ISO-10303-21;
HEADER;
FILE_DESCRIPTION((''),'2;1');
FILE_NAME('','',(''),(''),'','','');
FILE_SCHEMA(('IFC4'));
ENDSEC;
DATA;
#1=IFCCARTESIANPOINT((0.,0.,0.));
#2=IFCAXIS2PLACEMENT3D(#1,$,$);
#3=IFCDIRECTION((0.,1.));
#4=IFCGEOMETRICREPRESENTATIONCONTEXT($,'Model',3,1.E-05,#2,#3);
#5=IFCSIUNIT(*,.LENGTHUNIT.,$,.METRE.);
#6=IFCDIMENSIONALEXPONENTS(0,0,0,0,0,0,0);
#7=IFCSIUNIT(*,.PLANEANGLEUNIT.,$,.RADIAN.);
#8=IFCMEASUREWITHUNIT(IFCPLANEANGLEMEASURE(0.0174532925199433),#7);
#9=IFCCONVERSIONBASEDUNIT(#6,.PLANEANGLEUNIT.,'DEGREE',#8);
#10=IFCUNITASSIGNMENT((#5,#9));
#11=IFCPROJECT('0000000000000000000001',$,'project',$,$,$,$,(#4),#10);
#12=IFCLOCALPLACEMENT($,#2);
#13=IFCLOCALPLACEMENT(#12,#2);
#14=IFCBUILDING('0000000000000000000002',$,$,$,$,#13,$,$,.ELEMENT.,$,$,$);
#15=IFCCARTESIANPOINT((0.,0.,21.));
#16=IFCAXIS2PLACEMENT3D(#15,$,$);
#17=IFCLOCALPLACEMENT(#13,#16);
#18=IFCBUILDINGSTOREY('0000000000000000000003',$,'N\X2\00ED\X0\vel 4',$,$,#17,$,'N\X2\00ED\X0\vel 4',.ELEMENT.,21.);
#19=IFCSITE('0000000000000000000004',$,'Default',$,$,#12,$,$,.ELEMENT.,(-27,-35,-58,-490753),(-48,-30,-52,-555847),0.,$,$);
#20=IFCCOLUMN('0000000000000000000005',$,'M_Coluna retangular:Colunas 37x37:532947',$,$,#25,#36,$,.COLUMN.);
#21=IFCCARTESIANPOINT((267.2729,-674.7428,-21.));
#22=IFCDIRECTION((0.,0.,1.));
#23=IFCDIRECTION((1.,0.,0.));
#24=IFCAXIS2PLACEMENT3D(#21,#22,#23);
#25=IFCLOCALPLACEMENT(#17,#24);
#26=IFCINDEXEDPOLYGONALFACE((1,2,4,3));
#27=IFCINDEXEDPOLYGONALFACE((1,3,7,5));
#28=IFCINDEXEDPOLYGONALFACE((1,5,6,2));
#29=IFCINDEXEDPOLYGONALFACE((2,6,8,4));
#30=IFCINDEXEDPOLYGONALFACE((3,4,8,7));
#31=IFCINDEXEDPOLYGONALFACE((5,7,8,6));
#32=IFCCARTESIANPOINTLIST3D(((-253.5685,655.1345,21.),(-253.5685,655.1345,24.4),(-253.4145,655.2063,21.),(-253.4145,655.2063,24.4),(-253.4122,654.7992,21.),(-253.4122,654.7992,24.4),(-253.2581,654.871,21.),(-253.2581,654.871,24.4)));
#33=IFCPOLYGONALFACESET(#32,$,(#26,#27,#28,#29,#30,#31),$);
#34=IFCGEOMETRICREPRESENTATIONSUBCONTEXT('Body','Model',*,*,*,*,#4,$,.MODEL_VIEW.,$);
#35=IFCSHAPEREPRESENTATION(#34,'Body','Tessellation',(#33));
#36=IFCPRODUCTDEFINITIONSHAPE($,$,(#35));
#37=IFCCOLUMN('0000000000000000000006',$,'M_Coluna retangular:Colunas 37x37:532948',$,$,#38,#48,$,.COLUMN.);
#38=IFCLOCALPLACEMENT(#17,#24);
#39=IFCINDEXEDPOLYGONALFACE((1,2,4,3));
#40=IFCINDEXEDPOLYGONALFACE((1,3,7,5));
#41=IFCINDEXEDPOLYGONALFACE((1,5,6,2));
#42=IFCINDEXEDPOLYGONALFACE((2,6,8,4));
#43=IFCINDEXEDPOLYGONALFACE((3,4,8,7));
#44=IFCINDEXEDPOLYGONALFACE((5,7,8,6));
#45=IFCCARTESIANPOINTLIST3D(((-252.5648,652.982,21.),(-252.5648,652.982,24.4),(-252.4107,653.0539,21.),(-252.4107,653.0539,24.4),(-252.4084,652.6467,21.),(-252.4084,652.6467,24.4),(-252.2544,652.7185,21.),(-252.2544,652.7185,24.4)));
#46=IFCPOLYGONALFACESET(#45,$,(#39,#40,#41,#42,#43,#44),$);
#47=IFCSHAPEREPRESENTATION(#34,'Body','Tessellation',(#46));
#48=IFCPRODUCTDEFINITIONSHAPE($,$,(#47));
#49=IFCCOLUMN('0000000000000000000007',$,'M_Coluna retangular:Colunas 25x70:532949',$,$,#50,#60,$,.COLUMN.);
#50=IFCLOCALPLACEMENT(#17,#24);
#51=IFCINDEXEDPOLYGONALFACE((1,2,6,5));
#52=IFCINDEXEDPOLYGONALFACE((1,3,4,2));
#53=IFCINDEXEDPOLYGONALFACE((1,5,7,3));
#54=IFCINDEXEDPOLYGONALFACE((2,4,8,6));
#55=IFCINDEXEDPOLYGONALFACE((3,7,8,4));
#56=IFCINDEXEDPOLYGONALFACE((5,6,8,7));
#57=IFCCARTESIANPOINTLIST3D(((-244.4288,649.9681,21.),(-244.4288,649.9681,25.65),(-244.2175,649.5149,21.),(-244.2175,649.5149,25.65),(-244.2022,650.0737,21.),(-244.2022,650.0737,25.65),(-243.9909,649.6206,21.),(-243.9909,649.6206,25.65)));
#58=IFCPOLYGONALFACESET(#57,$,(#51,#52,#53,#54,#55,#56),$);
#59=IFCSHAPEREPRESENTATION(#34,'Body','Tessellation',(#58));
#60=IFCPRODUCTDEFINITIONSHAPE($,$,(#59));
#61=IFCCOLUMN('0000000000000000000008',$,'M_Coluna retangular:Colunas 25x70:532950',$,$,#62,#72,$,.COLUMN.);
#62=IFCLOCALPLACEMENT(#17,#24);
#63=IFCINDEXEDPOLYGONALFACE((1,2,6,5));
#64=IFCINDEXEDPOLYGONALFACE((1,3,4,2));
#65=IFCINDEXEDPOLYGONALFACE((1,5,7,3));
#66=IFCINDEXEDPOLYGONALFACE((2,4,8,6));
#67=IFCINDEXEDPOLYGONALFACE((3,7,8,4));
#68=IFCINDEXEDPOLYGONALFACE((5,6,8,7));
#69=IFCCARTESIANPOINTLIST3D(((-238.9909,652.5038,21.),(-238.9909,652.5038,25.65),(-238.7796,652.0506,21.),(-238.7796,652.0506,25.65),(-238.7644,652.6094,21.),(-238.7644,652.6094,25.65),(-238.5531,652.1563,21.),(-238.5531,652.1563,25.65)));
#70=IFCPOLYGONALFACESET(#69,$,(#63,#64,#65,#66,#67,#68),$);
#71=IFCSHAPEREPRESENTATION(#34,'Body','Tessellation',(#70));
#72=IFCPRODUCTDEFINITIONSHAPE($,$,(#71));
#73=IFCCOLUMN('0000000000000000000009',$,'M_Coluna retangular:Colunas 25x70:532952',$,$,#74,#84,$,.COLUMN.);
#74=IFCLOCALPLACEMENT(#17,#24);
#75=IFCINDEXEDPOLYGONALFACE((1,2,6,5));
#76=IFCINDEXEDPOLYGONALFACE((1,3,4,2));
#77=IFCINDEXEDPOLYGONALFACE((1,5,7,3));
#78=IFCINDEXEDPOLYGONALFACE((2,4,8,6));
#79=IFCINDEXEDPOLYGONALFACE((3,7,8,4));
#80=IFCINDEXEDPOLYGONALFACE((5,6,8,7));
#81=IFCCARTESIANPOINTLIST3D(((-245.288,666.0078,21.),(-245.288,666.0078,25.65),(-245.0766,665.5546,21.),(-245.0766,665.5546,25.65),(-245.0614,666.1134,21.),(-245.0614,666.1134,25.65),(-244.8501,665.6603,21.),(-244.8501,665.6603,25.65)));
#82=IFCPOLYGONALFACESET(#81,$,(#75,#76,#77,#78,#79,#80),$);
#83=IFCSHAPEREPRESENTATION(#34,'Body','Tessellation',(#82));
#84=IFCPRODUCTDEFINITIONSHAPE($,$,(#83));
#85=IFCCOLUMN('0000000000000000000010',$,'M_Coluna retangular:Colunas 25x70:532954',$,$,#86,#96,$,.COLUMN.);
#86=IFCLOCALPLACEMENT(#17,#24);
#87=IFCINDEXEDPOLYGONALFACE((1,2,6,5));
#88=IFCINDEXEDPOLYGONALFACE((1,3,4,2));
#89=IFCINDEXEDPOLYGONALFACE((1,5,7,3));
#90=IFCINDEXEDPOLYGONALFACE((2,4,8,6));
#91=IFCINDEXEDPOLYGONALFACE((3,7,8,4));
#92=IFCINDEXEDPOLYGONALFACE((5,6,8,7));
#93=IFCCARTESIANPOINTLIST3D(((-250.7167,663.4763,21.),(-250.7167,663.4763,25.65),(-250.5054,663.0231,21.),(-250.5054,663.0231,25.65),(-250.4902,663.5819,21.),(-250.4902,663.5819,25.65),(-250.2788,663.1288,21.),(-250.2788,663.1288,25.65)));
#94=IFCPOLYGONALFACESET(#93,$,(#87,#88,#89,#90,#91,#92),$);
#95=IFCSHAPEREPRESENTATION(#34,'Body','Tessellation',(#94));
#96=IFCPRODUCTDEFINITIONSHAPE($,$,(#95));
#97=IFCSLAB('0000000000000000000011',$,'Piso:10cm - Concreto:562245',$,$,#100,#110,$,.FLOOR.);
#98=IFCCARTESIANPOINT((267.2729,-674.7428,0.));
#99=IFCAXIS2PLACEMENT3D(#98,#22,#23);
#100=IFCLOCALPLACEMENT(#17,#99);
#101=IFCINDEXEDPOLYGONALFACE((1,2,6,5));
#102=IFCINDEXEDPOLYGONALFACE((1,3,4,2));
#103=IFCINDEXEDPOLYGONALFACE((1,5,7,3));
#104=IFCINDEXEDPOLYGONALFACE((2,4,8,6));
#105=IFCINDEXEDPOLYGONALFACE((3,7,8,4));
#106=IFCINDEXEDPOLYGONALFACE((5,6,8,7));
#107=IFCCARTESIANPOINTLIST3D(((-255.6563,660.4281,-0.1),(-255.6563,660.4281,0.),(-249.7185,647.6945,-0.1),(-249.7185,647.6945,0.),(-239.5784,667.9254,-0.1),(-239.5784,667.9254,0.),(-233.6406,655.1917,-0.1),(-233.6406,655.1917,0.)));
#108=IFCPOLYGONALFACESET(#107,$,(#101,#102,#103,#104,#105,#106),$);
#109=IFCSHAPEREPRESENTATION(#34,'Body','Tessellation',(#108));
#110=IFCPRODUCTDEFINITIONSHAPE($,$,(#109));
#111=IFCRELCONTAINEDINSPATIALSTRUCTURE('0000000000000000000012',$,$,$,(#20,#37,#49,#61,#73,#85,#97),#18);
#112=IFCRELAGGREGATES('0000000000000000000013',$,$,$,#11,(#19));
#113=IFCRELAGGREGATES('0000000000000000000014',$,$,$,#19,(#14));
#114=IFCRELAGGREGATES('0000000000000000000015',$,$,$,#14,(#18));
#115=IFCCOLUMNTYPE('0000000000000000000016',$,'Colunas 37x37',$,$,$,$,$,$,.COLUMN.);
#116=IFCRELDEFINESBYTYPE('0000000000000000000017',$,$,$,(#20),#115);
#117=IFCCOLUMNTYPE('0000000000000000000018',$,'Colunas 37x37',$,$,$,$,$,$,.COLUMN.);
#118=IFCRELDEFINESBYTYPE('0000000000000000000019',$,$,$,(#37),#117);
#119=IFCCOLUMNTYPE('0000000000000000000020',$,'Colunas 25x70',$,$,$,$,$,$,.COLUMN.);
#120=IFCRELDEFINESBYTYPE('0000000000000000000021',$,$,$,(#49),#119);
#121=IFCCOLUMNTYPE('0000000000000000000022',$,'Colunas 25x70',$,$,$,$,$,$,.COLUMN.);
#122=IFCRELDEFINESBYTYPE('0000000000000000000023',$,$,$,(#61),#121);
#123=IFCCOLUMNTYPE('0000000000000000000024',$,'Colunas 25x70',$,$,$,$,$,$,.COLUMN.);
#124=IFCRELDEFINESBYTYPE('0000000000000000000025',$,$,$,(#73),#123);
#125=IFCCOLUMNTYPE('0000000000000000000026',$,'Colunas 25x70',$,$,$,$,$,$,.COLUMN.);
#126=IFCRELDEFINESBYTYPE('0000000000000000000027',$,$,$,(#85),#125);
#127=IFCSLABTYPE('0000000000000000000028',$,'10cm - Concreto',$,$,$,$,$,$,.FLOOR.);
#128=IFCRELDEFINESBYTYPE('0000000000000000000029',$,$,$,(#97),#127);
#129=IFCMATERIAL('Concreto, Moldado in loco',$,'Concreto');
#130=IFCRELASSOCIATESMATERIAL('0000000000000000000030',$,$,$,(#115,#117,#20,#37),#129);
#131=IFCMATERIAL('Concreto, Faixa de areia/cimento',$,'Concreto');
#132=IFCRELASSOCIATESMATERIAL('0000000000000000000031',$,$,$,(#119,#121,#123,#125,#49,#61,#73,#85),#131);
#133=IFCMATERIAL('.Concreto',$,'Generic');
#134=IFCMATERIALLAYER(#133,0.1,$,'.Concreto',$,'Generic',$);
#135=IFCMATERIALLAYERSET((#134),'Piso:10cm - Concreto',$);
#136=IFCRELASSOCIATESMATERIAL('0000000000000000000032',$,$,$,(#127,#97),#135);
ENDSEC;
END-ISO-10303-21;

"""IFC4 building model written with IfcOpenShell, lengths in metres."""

from ifc_helpers import new_model, entity, si_unit, converted_unit, direction, frame, frame_2d, origin, origin_2d_with_axis, place, context, subcontext, project, spatial, rectangle, extrude, source, transform, mapped, material, layer, layer_set, layer_usage, material_profile, profile_set, profile_usage, type_object, type_shapes, element, save


model = new_model("IFC4")

# Units and contexts
model_context = context("Model", 3, precision=1e-05, world=origin(), true_north=direction((0.0, 1.0)))
body_context = subcontext(model_context, "Body", "Model", "MODEL_VIEW")
ifc_project = project(units=[si_unit("LENGTHUNIT", "METRE"), converted_unit("PLANEANGLEUNIT", "DEGREE", entity("IfcPlaneAngleMeasure", 0.0174532925199433), si_unit("PLANEANGLEUNIT", "RADIAN"), dimensions=[0, 0, 0, 0, 0, 0, 0])], contexts=[model_context])

# Site, building, storey
site_placement = place(None, origin())
site = spatial("IfcSite", under=ifc_project, at=site_placement, Name="Default", CompositionType="ELEMENT", RefLatitude=(-27, -35, -58, -490753), RefLongitude=(-48, -30, -52, -555847), RefElevation=0.0)
building_placement = place(site_placement, origin())
building = spatial("IfcBuilding", under=site, at=building_placement, CompositionType="ELEMENT")
storey_placement = place(building_placement, frame((0.0, 0.0, 21.0)))
storey = spatial("IfcBuildingStorey", under=building, at=storey_placement, Name="Nível 4", LongName="Nível 4", CompositionType="ELEMENT", Elevation=21.0)

# Columns
ifc_material_1 = material(Name="Concreto, Faixa de areia/cimento", Category="Concreto")
ifc_material_profile_1 = material_profile(ifc_material_1, rectangle(XDim=0.5, YDim=0.25, at=frame_2d((-0.05, 0.015), x_axis=(1.0, 0.0))), Name="Colunas 25x70")
ifc_profile_set_1 = profile_set([ifc_material_profile_1], Name="Colunas 25x70")
ifc_profile_usage_1 = profile_usage(ifc_profile_set_1)
ifc_material_2 = material(Name="Concreto, Moldado in loco", Category="Concreto")
ifc_material_profile_2 = material_profile(ifc_material_2, rectangle(XDim=0.37, YDim=0.37, at=origin_2d_with_axis()), Name="Colunas 37x37")
ifc_profile_set_2 = profile_set([ifc_material_profile_2], Name="Colunas 37x37")
ifc_profile_usage_2 = profile_usage(ifc_profile_set_2)
column_type_1 = type_object("IfcColumnType", Name="Colunas 37x37", PredefinedType="COLUMN", material=ifc_profile_set_2)
shared_shape_1 = source(origin(), body_context, "Body", "SweptSolid", [
    extrude(rectangle(XDim=0.17, YDim=0.37, at=frame_2d((0.0, 0.0), x_axis=(1.0, 0.0))), frame((-253.4133, 655.0027, 21.0), z_axis=(0.0, 0.0, 1.0), x_axis=(0.906308, 0.422618, 0.0)), (0.0, 0.0, 1.0), 3.4),
])
type_shapes(column_type_1, [shared_shape_1])
column_1_placement = place(storey_placement, frame((267.2729, -674.7428, -21.0), z_axis=(0.0, 0.0, 1.0), x_axis=(1.0, 0.0, 0.0)))
element("IfcColumn", 1, at=column_1_placement, inside=storey, type_object=column_type_1, material=ifc_profile_usage_2, Name="M_Coluna retangular:Colunas 37x37:532947", PredefinedType="COLUMN", context=body_context, shape_type="MappedRepresentation", body=[
    mapped(shared_shape_1, transform((0.0, 0.0, 0.0), scale=1.0)),
])
column_type_2 = type_object("IfcColumnType", Name="Colunas 37x37", PredefinedType="COLUMN", material=ifc_profile_set_2)
shared_shape_2 = source(origin(), body_context, "Body", "SweptSolid", [
    extrude(rectangle(XDim=0.17, YDim=0.37, at=frame_2d((0.0, 0.0), x_axis=(1.0, 0.0))), frame((-252.4096, 652.8503, 21.0), z_axis=(0.0, 0.0, 1.0), x_axis=(0.906308, 0.422618, 0.0)), (0.0, 0.0, 1.0), 3.4),
])
type_shapes(column_type_2, [shared_shape_2])
column_2_placement = place(storey_placement, frame((267.2729, -674.7428, -21.0), z_axis=(0.0, 0.0, 1.0), x_axis=(1.0, 0.0, 0.0)))
element("IfcColumn", 2, at=column_2_placement, inside=storey, type_object=column_type_2, material=ifc_profile_usage_2, Name="M_Coluna retangular:Colunas 37x37:532948", PredefinedType="COLUMN", context=body_context, shape_type="MappedRepresentation", body=[
    mapped(shared_shape_2, transform((0.0, 0.0, 0.0), scale=1.0)),
])
column_type_3 = type_object("IfcColumnType", Name="Colunas 25x70", PredefinedType="COLUMN", material=ifc_profile_set_1)
shared_shape_3 = source(origin(), body_context, "Body", "SweptSolid", [
    extrude(rectangle(XDim=0.5, YDim=0.25, at=frame_2d((0.0, 0.0), x_axis=(1.0, 0.0))), frame((-244.2098, 649.7943, 21.0), z_axis=(0.0, 0.0, 1.0), x_axis=(-0.422618, 0.906308, 0.0)), (0.0, 0.0, 1.0), 4.65),
])
type_shapes(column_type_3, [shared_shape_3])
column_3_placement = place(storey_placement, frame((267.2729, -674.7428, -21.0), z_axis=(0.0, 0.0, 1.0), x_axis=(1.0, 0.0, 0.0)))
element("IfcColumn", 3, at=column_3_placement, inside=storey, type_object=column_type_3, material=ifc_profile_usage_1, Name="M_Coluna retangular:Colunas 25x70:532949", PredefinedType="COLUMN", context=body_context, shape_type="MappedRepresentation", body=[
    mapped(shared_shape_3, transform((0.0, 0.0, 0.0), scale=1.0)),
])
column_type_4 = type_object("IfcColumnType", Name="Colunas 25x70", PredefinedType="COLUMN", material=ifc_profile_set_1)
shared_shape_4 = source(origin(), body_context, "Body", "SweptSolid", [
    extrude(rectangle(XDim=0.5, YDim=0.25, at=frame_2d((0.0, 0.0), x_axis=(1.0, 0.0))), frame((-238.772, 652.33, 21.0), z_axis=(0.0, 0.0, 1.0), x_axis=(-0.422618, 0.906308, 0.0)), (0.0, 0.0, 1.0), 4.65),
])
type_shapes(column_type_4, [shared_shape_4])
column_4_placement = place(storey_placement, frame((267.2729, -674.7428, -21.0), z_axis=(0.0, 0.0, 1.0), x_axis=(1.0, 0.0, 0.0)))
element("IfcColumn", 4, at=column_4_placement, inside=storey, type_object=column_type_4, material=ifc_profile_usage_1, Name="M_Coluna retangular:Colunas 25x70:532950", PredefinedType="COLUMN", context=body_context, shape_type="MappedRepresentation", body=[
    mapped(shared_shape_4, transform((0.0, 0.0, 0.0), scale=1.0)),
])
column_type_5 = type_object("IfcColumnType", Name="Colunas 25x70", PredefinedType="COLUMN", material=ifc_profile_set_1)
shared_shape_5 = source(origin(), body_context, "Body", "SweptSolid", [
    extrude(rectangle(XDim=0.5, YDim=0.25, at=frame_2d((0.0, 0.0), x_axis=(1.0, 0.0))), frame((-245.069, 665.834, 21.0), z_axis=(0.0, 0.0, 1.0), x_axis=(0.422618, -0.906308, 0.0)), (0.0, 0.0, 1.0), 4.65),
])
type_shapes(column_type_5, [shared_shape_5])
column_5_placement = place(storey_placement, frame((267.2729, -674.7428, -21.0), z_axis=(0.0, 0.0, 1.0), x_axis=(1.0, 0.0, 0.0)))
element("IfcColumn", 5, at=column_5_placement, inside=storey, type_object=column_type_5, material=ifc_profile_usage_1, Name="M_Coluna retangular:Colunas 25x70:532952", PredefinedType="COLUMN", context=body_context, shape_type="MappedRepresentation", body=[
    mapped(shared_shape_5, transform((0.0, 0.0, 0.0), scale=1.0)),
])
column_type_6 = type_object("IfcColumnType", Name="Colunas 25x70", PredefinedType="COLUMN", material=ifc_profile_set_1)
shared_shape_6 = source(origin(), body_context, "Body", "SweptSolid", [
    extrude(rectangle(XDim=0.5, YDim=0.25, at=frame_2d((0.0, 0.0), x_axis=(1.0, 0.0))), frame((-250.4978, 663.3025, 21.0), z_axis=(0.0, 0.0, 1.0), x_axis=(0.422618, -0.906308, 0.0)), (0.0, 0.0, 1.0), 4.65),
])
type_shapes(column_type_6, [shared_shape_6])
column_6_placement = place(storey_placement, frame((267.2729, -674.7428, -21.0), z_axis=(0.0, 0.0, 1.0), x_axis=(1.0, 0.0, 0.0)))
element("IfcColumn", 6, at=column_6_placement, inside=storey, type_object=column_type_6, material=ifc_profile_usage_1, Name="M_Coluna retangular:Colunas 25x70:532954", PredefinedType="COLUMN", context=body_context, shape_type="MappedRepresentation", body=[
    mapped(shared_shape_6, transform((0.0, 0.0, 0.0), scale=1.0)),
])

# Slab
ifc_material_3 = material(Name=".Concreto", Category="Generic")
ifc_layer_1 = layer(ifc_material_3, 0.1, Name=".Concreto", Category="Generic")
ifc_layer_set_1 = layer_set([ifc_layer_1], Name="Piso:10cm - Concreto")
ifc_layer_usage_1 = layer_usage(ifc_layer_set_1, "AXIS3", "POSITIVE", 0.0)
slab_type_1 = type_object("IfcSlabType", Name="10cm - Concreto", PredefinedType="FLOOR", material=ifc_layer_set_1)
slab_1_placement = place(storey_placement, frame((267.2729, -674.7428, 0.0), z_axis=(0.0, 0.0, 1.0), x_axis=(1.0, 0.0, 0.0)))
element("IfcSlab", 7, at=slab_1_placement, inside=storey, type_object=slab_type_1, material=ifc_layer_usage_1, Name="Piso:10cm - Concreto:562245", PredefinedType="FLOOR", context=body_context, shape_type="SweptSolid", body=[
    extrude(rectangle(XDim=17.74, YDim=14.05, at=frame_2d((0.0, 0.0), x_axis=(1.0, 0.0))), frame((-244.6485, 657.8099, 0.0), z_axis=(0.0, 0.0, -1.0), x_axis=(0.906308, 0.422618, 0.0)), (0.0, 0.0, 1.0), 0.1),
])

save(model, "model.ifc")
